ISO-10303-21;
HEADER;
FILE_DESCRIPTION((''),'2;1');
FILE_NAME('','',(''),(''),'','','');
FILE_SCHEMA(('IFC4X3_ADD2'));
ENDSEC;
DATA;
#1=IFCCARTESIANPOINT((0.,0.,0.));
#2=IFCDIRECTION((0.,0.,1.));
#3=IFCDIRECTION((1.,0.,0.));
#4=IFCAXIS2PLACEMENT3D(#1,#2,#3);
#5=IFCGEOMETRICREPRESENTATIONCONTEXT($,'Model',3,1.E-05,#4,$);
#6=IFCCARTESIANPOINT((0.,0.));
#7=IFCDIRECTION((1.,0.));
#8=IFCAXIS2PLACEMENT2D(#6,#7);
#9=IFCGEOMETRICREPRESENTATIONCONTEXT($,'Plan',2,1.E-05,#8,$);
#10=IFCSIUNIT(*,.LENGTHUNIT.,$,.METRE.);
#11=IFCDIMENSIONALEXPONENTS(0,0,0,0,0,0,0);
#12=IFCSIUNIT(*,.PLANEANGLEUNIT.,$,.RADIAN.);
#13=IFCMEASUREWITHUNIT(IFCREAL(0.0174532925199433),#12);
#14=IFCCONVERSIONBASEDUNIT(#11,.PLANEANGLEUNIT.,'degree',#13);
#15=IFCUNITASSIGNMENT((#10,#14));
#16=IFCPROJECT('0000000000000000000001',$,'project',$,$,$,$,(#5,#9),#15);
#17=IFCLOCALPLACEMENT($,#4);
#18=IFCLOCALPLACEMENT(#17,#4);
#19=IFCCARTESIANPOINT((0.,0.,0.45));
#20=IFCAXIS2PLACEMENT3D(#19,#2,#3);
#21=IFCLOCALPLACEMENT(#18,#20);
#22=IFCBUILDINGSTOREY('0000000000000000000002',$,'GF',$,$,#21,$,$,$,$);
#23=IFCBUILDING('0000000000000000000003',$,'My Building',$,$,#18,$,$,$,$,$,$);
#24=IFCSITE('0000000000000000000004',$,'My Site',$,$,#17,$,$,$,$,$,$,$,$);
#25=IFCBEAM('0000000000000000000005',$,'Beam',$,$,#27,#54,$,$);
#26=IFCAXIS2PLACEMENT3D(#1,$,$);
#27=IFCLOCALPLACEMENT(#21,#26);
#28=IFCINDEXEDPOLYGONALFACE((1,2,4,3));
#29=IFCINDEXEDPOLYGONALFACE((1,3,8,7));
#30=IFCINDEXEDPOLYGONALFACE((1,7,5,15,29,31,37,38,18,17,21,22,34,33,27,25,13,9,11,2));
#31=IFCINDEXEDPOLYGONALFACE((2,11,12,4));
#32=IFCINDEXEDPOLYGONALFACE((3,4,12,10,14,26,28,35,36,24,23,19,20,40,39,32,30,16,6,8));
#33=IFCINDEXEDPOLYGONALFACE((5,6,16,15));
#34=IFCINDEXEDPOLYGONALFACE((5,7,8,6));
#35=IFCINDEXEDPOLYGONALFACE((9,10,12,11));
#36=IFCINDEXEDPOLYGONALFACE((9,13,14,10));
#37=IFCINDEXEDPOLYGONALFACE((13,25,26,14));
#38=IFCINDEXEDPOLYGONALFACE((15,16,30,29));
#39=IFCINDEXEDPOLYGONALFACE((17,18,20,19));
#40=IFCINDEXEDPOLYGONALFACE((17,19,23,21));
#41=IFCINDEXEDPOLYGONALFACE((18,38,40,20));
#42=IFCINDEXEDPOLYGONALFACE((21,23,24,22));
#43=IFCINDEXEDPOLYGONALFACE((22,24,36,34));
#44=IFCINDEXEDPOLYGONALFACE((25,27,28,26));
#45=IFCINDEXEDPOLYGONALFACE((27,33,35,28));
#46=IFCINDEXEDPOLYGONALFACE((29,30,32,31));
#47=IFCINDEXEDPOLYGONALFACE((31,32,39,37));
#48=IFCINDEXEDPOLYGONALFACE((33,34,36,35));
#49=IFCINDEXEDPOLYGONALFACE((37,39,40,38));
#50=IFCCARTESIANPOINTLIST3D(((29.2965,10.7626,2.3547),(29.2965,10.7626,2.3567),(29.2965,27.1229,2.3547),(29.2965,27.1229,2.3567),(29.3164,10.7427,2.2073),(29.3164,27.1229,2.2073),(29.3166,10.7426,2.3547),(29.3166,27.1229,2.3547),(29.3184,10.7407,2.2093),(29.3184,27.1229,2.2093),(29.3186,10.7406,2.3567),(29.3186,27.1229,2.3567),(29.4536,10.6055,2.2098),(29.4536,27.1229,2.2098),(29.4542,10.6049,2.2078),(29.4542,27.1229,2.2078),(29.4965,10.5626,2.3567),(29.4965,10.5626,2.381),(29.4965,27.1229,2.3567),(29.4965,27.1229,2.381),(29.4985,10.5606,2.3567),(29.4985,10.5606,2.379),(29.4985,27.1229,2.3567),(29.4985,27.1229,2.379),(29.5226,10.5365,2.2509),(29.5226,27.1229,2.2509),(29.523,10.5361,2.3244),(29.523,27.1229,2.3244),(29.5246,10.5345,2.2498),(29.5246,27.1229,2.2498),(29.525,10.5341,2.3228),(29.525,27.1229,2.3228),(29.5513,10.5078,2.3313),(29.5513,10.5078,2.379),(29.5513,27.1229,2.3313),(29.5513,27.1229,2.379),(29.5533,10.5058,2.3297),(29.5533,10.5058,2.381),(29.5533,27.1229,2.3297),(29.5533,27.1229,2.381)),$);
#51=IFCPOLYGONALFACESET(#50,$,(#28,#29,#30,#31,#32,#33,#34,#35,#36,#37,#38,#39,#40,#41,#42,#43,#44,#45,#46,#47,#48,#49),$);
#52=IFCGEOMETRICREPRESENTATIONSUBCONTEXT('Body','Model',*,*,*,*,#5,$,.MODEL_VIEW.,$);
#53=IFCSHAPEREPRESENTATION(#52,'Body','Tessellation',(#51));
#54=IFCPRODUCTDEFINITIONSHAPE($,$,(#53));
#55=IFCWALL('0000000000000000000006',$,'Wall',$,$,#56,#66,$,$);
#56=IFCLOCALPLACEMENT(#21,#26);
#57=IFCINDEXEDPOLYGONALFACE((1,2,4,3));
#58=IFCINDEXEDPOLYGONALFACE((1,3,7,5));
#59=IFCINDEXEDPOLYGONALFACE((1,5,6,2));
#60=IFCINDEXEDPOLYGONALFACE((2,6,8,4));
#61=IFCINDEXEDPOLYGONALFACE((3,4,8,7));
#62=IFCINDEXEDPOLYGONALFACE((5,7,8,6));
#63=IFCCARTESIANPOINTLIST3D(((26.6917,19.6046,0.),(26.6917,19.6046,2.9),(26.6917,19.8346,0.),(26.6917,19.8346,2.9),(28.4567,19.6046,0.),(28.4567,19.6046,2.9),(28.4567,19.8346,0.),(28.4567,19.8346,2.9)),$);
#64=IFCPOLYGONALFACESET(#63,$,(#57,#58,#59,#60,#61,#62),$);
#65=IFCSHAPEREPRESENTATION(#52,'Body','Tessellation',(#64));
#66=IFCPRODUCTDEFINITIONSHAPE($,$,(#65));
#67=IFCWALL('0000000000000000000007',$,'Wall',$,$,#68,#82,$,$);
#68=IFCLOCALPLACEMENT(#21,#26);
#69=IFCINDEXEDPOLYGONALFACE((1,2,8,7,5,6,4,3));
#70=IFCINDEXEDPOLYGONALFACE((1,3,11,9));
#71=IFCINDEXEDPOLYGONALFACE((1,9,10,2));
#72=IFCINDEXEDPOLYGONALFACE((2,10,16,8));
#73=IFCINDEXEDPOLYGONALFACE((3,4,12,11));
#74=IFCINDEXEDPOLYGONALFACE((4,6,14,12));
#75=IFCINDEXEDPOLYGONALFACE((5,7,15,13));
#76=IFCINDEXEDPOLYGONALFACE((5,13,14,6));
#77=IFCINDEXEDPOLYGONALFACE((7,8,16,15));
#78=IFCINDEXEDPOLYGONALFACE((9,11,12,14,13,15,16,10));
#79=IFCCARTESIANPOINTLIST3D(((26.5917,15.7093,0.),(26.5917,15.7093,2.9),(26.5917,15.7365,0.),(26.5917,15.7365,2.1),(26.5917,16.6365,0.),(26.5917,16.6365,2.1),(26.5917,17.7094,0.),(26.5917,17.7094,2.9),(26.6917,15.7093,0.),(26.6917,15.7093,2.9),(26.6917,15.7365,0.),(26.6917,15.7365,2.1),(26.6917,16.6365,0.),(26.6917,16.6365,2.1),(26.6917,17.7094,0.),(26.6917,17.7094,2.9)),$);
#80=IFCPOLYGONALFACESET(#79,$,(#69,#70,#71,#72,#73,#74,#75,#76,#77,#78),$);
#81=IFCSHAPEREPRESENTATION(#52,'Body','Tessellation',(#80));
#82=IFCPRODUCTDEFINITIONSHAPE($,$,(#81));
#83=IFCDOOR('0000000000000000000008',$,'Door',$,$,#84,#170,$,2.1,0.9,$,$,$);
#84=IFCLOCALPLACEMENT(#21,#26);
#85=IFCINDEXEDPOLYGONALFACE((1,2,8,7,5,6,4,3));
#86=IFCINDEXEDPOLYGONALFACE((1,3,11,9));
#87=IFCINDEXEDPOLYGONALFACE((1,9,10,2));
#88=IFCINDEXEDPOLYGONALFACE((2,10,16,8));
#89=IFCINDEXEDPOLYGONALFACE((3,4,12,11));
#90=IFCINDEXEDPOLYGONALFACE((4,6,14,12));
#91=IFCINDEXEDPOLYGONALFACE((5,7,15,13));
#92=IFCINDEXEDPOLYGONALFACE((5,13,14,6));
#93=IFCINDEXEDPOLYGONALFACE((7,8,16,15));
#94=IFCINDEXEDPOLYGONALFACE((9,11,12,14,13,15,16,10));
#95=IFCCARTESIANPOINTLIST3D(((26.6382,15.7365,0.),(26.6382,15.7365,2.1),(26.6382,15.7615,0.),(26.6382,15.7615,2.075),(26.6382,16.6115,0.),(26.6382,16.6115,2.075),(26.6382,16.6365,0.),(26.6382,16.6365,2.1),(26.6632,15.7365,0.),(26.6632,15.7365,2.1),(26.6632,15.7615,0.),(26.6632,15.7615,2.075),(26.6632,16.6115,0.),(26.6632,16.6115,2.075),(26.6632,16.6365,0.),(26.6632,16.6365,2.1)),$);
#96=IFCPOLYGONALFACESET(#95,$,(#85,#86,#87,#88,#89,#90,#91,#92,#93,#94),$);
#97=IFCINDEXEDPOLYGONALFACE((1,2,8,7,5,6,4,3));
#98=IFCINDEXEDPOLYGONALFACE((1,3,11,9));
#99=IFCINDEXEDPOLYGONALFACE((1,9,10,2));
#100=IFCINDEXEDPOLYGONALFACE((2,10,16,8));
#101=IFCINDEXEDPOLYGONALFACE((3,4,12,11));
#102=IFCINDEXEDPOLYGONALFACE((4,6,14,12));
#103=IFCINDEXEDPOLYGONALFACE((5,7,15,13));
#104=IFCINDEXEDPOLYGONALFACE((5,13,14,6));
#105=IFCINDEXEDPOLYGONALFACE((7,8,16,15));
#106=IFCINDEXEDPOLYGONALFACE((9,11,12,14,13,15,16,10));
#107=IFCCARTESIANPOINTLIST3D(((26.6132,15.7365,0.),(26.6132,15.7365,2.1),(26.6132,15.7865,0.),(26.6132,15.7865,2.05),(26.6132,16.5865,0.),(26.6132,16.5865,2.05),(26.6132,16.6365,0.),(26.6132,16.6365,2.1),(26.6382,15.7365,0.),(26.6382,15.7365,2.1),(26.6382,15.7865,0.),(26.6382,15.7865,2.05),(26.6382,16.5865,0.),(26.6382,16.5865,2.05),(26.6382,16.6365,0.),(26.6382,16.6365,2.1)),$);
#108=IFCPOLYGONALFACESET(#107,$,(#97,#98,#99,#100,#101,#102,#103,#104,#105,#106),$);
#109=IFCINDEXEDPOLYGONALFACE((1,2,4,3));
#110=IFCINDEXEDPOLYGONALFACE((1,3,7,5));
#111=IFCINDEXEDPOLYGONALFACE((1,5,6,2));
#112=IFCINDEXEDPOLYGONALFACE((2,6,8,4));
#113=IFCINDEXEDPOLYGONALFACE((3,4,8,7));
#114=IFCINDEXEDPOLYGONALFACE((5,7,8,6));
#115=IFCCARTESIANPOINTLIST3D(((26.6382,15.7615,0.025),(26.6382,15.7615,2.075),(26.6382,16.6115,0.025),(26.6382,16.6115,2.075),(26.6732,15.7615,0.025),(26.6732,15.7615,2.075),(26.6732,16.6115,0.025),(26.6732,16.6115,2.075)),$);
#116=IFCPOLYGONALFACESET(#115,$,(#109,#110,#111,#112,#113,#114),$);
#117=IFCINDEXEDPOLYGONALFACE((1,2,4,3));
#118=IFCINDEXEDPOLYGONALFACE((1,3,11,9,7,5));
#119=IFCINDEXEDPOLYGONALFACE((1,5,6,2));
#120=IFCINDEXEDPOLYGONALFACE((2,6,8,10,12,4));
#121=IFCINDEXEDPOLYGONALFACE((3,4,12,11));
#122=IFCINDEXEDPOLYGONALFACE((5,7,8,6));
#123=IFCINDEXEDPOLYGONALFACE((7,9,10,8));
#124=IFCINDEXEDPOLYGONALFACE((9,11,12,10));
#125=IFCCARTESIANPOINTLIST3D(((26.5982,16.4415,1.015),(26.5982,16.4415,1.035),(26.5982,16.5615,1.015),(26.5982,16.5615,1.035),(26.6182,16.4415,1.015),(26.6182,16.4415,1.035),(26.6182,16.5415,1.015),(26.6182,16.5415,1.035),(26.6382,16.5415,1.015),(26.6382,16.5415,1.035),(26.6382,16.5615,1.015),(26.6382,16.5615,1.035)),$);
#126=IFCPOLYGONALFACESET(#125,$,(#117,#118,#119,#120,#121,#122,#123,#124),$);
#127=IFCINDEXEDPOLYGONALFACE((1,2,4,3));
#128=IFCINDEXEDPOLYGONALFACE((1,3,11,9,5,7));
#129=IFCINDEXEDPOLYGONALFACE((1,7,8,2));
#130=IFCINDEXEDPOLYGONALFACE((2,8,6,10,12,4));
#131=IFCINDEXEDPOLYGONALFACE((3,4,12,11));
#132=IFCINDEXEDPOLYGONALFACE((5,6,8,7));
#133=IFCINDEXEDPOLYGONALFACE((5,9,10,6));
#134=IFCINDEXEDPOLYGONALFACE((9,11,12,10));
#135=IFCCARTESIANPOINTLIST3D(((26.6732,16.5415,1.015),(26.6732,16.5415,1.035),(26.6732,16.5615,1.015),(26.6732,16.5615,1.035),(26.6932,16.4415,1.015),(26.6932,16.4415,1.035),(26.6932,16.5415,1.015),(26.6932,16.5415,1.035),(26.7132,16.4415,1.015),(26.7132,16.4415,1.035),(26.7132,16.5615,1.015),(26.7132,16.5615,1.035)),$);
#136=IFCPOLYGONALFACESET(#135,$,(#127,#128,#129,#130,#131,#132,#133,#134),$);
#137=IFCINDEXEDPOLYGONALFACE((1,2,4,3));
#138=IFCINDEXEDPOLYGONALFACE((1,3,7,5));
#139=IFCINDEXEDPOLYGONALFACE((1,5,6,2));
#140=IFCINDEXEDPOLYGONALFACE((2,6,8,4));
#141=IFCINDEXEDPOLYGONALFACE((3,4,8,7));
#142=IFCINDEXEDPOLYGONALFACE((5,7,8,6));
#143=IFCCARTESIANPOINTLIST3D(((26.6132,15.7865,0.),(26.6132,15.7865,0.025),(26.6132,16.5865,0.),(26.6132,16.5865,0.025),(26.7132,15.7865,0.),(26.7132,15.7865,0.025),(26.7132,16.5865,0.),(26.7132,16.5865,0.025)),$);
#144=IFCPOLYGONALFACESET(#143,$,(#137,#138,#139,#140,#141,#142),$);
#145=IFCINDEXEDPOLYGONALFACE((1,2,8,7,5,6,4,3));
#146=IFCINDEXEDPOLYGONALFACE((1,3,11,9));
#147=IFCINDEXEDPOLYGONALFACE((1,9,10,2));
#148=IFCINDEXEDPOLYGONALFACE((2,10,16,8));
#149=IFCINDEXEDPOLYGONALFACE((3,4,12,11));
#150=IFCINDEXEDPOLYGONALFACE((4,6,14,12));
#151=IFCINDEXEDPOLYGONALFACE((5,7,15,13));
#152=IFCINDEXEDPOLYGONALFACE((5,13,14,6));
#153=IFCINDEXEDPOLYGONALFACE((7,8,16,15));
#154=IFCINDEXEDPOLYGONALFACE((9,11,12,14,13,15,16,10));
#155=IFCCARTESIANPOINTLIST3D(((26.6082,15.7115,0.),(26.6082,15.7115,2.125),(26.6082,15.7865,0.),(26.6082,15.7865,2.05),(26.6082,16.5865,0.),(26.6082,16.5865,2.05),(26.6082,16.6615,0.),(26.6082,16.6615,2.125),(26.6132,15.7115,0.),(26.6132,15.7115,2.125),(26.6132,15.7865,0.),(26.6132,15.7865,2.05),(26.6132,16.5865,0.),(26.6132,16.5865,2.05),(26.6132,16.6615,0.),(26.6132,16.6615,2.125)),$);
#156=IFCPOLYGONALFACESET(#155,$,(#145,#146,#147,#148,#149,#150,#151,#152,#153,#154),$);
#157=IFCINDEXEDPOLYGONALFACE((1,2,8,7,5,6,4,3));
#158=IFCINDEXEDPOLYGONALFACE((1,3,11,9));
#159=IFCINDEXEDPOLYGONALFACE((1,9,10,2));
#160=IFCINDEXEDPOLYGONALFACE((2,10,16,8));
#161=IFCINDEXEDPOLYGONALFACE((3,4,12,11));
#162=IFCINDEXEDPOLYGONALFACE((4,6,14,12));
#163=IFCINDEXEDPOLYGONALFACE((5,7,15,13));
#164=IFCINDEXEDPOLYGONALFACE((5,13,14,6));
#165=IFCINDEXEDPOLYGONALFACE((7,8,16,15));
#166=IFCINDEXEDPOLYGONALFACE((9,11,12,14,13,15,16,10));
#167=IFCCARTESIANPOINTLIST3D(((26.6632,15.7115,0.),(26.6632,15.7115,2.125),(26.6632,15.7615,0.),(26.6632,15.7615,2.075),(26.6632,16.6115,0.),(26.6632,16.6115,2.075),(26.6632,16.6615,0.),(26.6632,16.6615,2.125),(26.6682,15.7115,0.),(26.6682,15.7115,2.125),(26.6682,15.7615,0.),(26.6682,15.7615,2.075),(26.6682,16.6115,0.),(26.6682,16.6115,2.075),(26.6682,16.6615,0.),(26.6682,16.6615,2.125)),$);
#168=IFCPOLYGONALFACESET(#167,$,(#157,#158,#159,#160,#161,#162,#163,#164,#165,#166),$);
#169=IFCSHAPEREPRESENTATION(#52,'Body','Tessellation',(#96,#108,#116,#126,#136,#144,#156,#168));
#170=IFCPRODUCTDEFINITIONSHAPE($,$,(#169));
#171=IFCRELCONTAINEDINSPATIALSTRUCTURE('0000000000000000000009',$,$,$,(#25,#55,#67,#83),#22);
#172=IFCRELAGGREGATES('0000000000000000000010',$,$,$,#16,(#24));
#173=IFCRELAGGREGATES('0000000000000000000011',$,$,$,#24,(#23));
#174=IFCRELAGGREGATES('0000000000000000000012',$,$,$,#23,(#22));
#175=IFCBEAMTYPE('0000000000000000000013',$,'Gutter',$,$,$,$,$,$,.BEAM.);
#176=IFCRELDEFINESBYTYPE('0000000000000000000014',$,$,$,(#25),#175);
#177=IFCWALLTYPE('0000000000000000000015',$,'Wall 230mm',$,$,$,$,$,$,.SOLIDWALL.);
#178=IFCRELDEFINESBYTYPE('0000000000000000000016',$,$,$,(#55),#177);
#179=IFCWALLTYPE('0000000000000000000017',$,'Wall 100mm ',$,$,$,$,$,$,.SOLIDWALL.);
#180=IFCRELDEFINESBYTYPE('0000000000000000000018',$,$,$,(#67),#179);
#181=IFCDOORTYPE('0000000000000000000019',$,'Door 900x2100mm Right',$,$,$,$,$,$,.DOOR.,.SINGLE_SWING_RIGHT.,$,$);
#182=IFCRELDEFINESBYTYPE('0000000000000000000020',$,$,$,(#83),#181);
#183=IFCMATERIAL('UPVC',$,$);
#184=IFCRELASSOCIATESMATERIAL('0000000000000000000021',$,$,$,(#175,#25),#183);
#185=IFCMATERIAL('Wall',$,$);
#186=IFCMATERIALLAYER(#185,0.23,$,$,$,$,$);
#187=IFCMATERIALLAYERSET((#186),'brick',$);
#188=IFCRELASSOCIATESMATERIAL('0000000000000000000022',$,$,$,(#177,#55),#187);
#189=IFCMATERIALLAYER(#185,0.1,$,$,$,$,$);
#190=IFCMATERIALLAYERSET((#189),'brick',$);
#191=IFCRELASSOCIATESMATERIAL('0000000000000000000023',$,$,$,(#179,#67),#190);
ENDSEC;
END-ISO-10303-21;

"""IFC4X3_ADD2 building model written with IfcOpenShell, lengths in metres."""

from ifc_helpers import new_model, entity, si_unit, converted_unit, frame, origin_with_axes, origin_2d_with_axis, place, context, subcontext, project, spatial, line, indexed_curve, outline, extrude, clip, halfspace, shape, source, transform, mapped, material, layer, layer_set, layer_usage, material_profile, profile_set, profile_usage, type_object, type_shapes, element, fill, save


model = new_model("IFC4X3_ADD2")

# Units and contexts
model_context = context("Model", 3, precision=1e-05, world=origin_with_axes())
plan_context = context("Plan", 2, precision=1e-05, world=origin_2d_with_axis())
body_context_1 = subcontext(model_context, "Body", "Model", "MODEL_VIEW")
body_context_2 = subcontext(plan_context, "Body", "Plan", "PLAN_VIEW")
ifc_project = project(units=[si_unit("LENGTHUNIT", "METRE"), converted_unit("PLANEANGLEUNIT", "degree", entity("IfcReal", 0.0174532925199433), si_unit("PLANEANGLEUNIT", "RADIAN"), dimensions=[0, 0, 0, 0, 0, 0, 0])], contexts=[model_context, plan_context])

# Site, building, storey
site_placement = place(None, origin_with_axes())
site = spatial("IfcSite", under=ifc_project, at=site_placement, Name="My Site")
building_placement = place(site_placement, origin_with_axes())
building = spatial("IfcBuilding", under=site, at=building_placement, Name="My Building")
storey_placement = place(building_placement, frame((0.0, 0.0, 0.45), z_axis=(0.0, 0.0, 1.0), x_axis=(1.0, 0.0, 0.0)))
storey = spatial("IfcBuildingStorey", under=building, at=storey_placement, Name="GF")

# Beam
ifc_material_1 = material(Name="UPVC")
ifc_material_profile_1 = material_profile(ifc_material_1, outline(indexed_curve([(0.0548, 0.1717), (0.002, 0.1717), (0.002, 0.124), (0.0303, 0.1171), (0.0307, 0.0436), (0.0996, 0.0025), (0.2349, 0.002), (0.2347, 0.1494), (0.2567, 0.1494), (0.2567, 0.1474), (0.2367, 0.1474), (0.2369, 0.0), (0.0991, 0.0005), (0.0287, 0.0425), (0.0283, 0.1155), (0.0, 0.1224), (0.0, 0.1737), (0.0568, 0.1737), (0.0568, 0.1494), (0.0548, 0.1494), (0.0548, 0.1717)])))
ifc_profile_set_1 = profile_set([ifc_material_profile_1])
ifc_profile_usage_1 = profile_usage(ifc_profile_set_1, cardinal=5)
beam_type = type_object("IfcBeamType", Name="Gutter", PredefinedType="BEAM", material=ifc_profile_set_1)
beam_placement = place(storey_placement, frame((29.5533, 10.5058, 2.2073), z_axis=(0.0, 1.0, 0.0), x_axis=(-1.0, 0.0, 0.0)))
element("IfcBeam", 1, at=beam_placement, inside=storey, type_object=beam_type, material=ifc_profile_usage_1, Name="Beam", context=body_context_1, shape_type="Clipping", body=[
    clip(extrude(outline(indexed_curve([(0.0548, 0.1717), (0.002, 0.1717), (0.002, 0.124), (0.0303, 0.1171), (0.0307, 0.0436), (0.0996, 0.0025), (0.2349, 0.002), (0.2347, 0.1494), (0.2567, 0.1494), (0.2567, 0.1474), (0.2367, 0.1474), (0.2369, 0.0), (0.0991, 0.0005), (0.0287, 0.0425), (0.0283, 0.1155), (0.0, 0.1224), (0.0, 0.1737), (0.0568, 0.1737), (0.0568, 0.1494), (0.0548, 0.1494), (0.0548, 0.1717)])), origin_with_axes(), (0.0, 0.0, 1.0), 16.6171), halfspace(frame((0.0, -2.8276, 0.0), z_axis=(0.707107, 0.0, -0.707107), x_axis=(0.0, -1.0, 0.0)), False)),
])

# Wall
ifc_material_2 = material(Name="Wall")
ifc_layer_1 = layer(ifc_material_2, 0.23)
ifc_layer_set_1 = layer_set([ifc_layer_1], Name="brick")
ifc_layer_usage_1 = layer_usage(ifc_layer_set_1, "AXIS2", "POSITIVE", 0.0)
wall_type_1 = type_object("IfcWallType", Name="Wall 230mm", PredefinedType="SOLIDWALL", material=ifc_layer_set_1)
wall_1_placement = place(storey_placement, frame((26.6917, 19.6046, 0.0), z_axis=(0.0, 0.0, 1.0), x_axis=(1.0, 0.0, 0.0)))
element("IfcWall", 2, at=wall_1_placement, inside=storey, type_object=wall_type_1, material=ifc_layer_usage_1, Name="Wall", context=body_context_1, shape_type="SweptSolid", body=[
    extrude(outline(indexed_curve([(0.0, 0.0), (0.0, 0.23), (1.765, 0.23), (1.765, 0.0), (0.0, 0.0)], self_intersect=False)), origin_with_axes(), (0.0, 0.0, 1.0), 2.9),
])

# Wall, opening, door
ifc_layer_2 = layer(ifc_material_2, 0.1)
ifc_layer_set_2 = layer_set([ifc_layer_2], Name="brick")
ifc_layer_usage_2 = layer_usage(ifc_layer_set_2, "AXIS2", "POSITIVE", 0.0)
wall_type_2 = type_object("IfcWallType", Name="Wall 100mm ", PredefinedType="SOLIDWALL", material=ifc_layer_set_2)
wall_2_placement = place(storey_placement, frame((26.6917, 15.7093, 0.0), z_axis=(0.0, 0.0, 1.0), x_axis=(0.0, 1.0, 0.0)))
wall_2 = element("IfcWall", 3, at=wall_2_placement, inside=storey, type_object=wall_type_2, material=ifc_layer_usage_2, Name="Wall", context=body_context_1, shape_type="SweptSolid", body=[
    extrude(outline(indexed_curve([(0.0, 0.0), (0.0, 0.1), (2.0, 0.1), (2.0, 0.0), (0.0, 0.0)], self_intersect=False)), origin_with_axes(), (0.0, 0.0, 1.0), 2.9),
])
shared_shape_1 = source(origin_with_axes(), body_context_1, "Body", "SweptSolid", [
    extrude(outline(indexed_curve([(0.0, 0.0), (0.9, 0.0), (0.9, 2.1), (0.0, 2.1)], segments=[line(1, 2, 3, 4, 1)])), frame((0.0, -0.6, 0.0), z_axis=(0.0, -1.0, 0.0), x_axis=(1.0, 0.0, 0.0)), (0.0, 0.0, -1.0), 1.2),
])
opening_1_placement = place(wall_2_placement, frame((0.9271, 0.0785, 0.0), z_axis=(0.0, 0.0, 1.0), x_axis=(-1.0, 0.0, 0.0)))
opening_1 = element("IfcOpeningElement", 4, at=opening_1_placement, cuts=wall_2, PredefinedType="OPENING", context=body_context_1, shape_type="MappedRepresentation", body=[
    mapped(shared_shape_1, transform((0.0, 0.0, 0.0), x_axis=(1.0, 0.0, 0.0), y_axis=(0.0, 1.0, 0.0), z_axis=(0.0, 0.0, 1.0), scale=1.0)),
])
door_type_1 = type_object("IfcDoorType", Name="Door 900x2100mm Right", OperationType="SINGLE_SWING_RIGHT", PredefinedType="DOOR")
shared_shape_2 = source(origin_with_axes(), body_context_1, "Body", "SweptSolid", [
    extrude(outline(indexed_curve([(0.0, 0.0), (0.0, 2.1), (0.9, 2.1), (0.9, 0.0), (0.875, 0.0), (0.875, 2.075), (0.025, 2.075), (0.025, 0.0)], segments=[line(1, 2, 3, 4, 5, 6, 7, 8, 1)])), frame((0.0, 0.025, 0.0), z_axis=(0.0, -1.0, 0.0), x_axis=(1.0, 0.0, 0.0)), (0.0, 0.0, -1.0), 0.025),
    extrude(outline(indexed_curve([(0.0, 0.0), (0.0, 2.1), (0.9, 2.1), (0.9, 0.0), (0.85, 0.0), (0.85, 2.05), (0.05, 2.05), (0.05, 0.0)], segments=[line(1, 2, 3, 4, 5, 6, 7, 8, 1)])), frame((0.0, 0.0, 0.0), z_axis=(0.0, -1.0, 0.0), x_axis=(1.0, 0.0, 0.0)), (0.0, 0.0, -1.0), 0.025),
    extrude(outline(indexed_curve([(0.0, 0.0), (0.85, 0.0), (0.85, 0.035), (0.0, 0.035)], segments=[line(1, 2, 3, 4, 1)])), frame((0.025, 0.025, 0.025), z_axis=(0.0, 0.0, 1.0), x_axis=(1.0, 0.0, 0.0)), (0.0, 0.0, 1.0), 2.05),
    extrude(outline(indexed_curve([(0.0, 0.0), (0.0, -0.04), (0.12, -0.04), (0.12, -0.02), (0.02, -0.02), (0.02, 0.0)], segments=[line(1, 2, 3, 4, 5, 6, 1)])), frame((0.075, 0.025, 1.015), z_axis=(0.0, 0.0, 1.0), x_axis=(1.0, 0.0, 0.0)), (0.0, 0.0, 1.0), 0.02),
    extrude(outline(indexed_curve([(0.0, 0.0), (0.0, 0.04), (0.12, 0.04), (0.12, 0.02), (0.02, 0.02), (0.02, 0.0)], segments=[line(1, 2, 3, 4, 5, 6, 1)])), frame((0.075, 0.06, 1.015), z_axis=(0.0, 0.0, 1.0), x_axis=(1.0, 0.0, 0.0)), (0.0, 0.0, 1.0), 0.02),
    extrude(outline(indexed_curve([(0.0, 0.0), (0.8, 0.0), (0.8, 0.1), (0.0, 0.1)], segments=[line(1, 2, 3, 4, 1)])), frame((0.05, 0.0, 0.0), z_axis=(0.0, 0.0, 1.0), x_axis=(1.0, 0.0, 0.0)), (0.0, 0.0, 1.0), 0.025),
    extrude(outline(indexed_curve([(0.0, 0.0), (0.0, 2.125), (0.95, 2.125), (0.95, 0.0), (0.875, 0.0), (0.875, 2.05), (0.075, 2.05), (0.075, 0.0)], segments=[line(1, 2, 3, 4, 5, 6, 7, 8, 1)])), frame((-0.025, -0.005, 0.0), z_axis=(0.0, -1.0, 0.0), x_axis=(1.0, 0.0, 0.0)), (0.0, 0.0, -1.0), 0.005),
    extrude(outline(indexed_curve([(0.0, 0.0), (0.0, 2.125), (0.95, 2.125), (0.95, 0.0), (0.9, 0.0), (0.9, 2.075), (0.05, 2.075), (0.05, 0.0)], segments=[line(1, 2, 3, 4, 5, 6, 7, 8, 1)])), frame((-0.025, 0.05, 0.0), z_axis=(0.0, -1.0, 0.0), x_axis=(1.0, 0.0, 0.0)), (0.0, 0.0, -1.0), 0.005),
])
shared_shape_3 = source(origin_with_axes(), body_context_2, "Body", "Curve2D", [
    entity("IfcIndexedPolyCurve", entity("IfcCartesianPointList2D", [[0.0, 0.0], [0.0, 0.05], [0.025, 0.05], [0.025, 0.025], [0.05, 0.025], [0.05, 0.0]]), [entity("IfcLineIndex", [1, 2, 3, 4, 5, 6, 1])]),
    entity("IfcIndexedPolyCurve", entity("IfcCartesianPointList2D", [[0.9, 0.0], [0.9, 0.05], [0.875, 0.05], [0.875, 0.025], [0.85, 0.025], [0.85, 0.0]]), [entity("IfcLineIndex", [1, 2, 3, 4, 5, 6, 1])]),
    entity("IfcTrimmedCurve", entity("IfcEllipse", entity("IfcAxis2Placement2D", entity("IfcCartesianPoint", [0.84, 0.05]), entity("IfcDirection", [1.0, 0.0])), 0.815, 0.85), [entity("IfcCartesianPoint", [0.84, 0.9])], [entity("IfcCartesianPoint", [0.025, 0.05])], True, "CARTESIAN"),
    entity("IfcIndexedPolyCurve", entity("IfcCartesianPointList2D", [[0.875, 0.05], [0.84, 0.05], [0.84, 0.9], [0.875, 0.9]]), [entity("IfcLineIndex", [1, 2, 3, 4, 1])]),
])
type_shapes(door_type_1, [shared_shape_2, shared_shape_3])
door_1_placement = place(opening_1_placement, frame((0.0, 0.0, 0.0), z_axis=(0.0, 0.0, 1.0), x_axis=(1.0, 0.0, 0.0)))
door_1 = element("IfcDoor", 5, at=door_1_placement, inside=storey, type_object=door_type_1, Name="Door", OverallHeight=2.1, OverallWidth=0.9, shapes=[
    shape(body_context_1, "Body", "MappedRepresentation", [mapped(shared_shape_2, transform((0.0, 0.0, 0.0), x_axis=(1.0, 0.0, 0.0), y_axis=(0.0, 1.0, 0.0), z_axis=(0.0, 0.0, 1.0), scale=1.0))]),
    shape(body_context_2, "Body", "MappedRepresentation", [mapped(shared_shape_3, transform((0.0, 0.0, 0.0), x_axis=(1.0, 0.0, 0.0), y_axis=(0.0, 1.0, 0.0), z_axis=(0.0, 0.0, 1.0), scale=1.0))]),
])
fill(opening_1, door_1)

save(model, "model.ifc")
